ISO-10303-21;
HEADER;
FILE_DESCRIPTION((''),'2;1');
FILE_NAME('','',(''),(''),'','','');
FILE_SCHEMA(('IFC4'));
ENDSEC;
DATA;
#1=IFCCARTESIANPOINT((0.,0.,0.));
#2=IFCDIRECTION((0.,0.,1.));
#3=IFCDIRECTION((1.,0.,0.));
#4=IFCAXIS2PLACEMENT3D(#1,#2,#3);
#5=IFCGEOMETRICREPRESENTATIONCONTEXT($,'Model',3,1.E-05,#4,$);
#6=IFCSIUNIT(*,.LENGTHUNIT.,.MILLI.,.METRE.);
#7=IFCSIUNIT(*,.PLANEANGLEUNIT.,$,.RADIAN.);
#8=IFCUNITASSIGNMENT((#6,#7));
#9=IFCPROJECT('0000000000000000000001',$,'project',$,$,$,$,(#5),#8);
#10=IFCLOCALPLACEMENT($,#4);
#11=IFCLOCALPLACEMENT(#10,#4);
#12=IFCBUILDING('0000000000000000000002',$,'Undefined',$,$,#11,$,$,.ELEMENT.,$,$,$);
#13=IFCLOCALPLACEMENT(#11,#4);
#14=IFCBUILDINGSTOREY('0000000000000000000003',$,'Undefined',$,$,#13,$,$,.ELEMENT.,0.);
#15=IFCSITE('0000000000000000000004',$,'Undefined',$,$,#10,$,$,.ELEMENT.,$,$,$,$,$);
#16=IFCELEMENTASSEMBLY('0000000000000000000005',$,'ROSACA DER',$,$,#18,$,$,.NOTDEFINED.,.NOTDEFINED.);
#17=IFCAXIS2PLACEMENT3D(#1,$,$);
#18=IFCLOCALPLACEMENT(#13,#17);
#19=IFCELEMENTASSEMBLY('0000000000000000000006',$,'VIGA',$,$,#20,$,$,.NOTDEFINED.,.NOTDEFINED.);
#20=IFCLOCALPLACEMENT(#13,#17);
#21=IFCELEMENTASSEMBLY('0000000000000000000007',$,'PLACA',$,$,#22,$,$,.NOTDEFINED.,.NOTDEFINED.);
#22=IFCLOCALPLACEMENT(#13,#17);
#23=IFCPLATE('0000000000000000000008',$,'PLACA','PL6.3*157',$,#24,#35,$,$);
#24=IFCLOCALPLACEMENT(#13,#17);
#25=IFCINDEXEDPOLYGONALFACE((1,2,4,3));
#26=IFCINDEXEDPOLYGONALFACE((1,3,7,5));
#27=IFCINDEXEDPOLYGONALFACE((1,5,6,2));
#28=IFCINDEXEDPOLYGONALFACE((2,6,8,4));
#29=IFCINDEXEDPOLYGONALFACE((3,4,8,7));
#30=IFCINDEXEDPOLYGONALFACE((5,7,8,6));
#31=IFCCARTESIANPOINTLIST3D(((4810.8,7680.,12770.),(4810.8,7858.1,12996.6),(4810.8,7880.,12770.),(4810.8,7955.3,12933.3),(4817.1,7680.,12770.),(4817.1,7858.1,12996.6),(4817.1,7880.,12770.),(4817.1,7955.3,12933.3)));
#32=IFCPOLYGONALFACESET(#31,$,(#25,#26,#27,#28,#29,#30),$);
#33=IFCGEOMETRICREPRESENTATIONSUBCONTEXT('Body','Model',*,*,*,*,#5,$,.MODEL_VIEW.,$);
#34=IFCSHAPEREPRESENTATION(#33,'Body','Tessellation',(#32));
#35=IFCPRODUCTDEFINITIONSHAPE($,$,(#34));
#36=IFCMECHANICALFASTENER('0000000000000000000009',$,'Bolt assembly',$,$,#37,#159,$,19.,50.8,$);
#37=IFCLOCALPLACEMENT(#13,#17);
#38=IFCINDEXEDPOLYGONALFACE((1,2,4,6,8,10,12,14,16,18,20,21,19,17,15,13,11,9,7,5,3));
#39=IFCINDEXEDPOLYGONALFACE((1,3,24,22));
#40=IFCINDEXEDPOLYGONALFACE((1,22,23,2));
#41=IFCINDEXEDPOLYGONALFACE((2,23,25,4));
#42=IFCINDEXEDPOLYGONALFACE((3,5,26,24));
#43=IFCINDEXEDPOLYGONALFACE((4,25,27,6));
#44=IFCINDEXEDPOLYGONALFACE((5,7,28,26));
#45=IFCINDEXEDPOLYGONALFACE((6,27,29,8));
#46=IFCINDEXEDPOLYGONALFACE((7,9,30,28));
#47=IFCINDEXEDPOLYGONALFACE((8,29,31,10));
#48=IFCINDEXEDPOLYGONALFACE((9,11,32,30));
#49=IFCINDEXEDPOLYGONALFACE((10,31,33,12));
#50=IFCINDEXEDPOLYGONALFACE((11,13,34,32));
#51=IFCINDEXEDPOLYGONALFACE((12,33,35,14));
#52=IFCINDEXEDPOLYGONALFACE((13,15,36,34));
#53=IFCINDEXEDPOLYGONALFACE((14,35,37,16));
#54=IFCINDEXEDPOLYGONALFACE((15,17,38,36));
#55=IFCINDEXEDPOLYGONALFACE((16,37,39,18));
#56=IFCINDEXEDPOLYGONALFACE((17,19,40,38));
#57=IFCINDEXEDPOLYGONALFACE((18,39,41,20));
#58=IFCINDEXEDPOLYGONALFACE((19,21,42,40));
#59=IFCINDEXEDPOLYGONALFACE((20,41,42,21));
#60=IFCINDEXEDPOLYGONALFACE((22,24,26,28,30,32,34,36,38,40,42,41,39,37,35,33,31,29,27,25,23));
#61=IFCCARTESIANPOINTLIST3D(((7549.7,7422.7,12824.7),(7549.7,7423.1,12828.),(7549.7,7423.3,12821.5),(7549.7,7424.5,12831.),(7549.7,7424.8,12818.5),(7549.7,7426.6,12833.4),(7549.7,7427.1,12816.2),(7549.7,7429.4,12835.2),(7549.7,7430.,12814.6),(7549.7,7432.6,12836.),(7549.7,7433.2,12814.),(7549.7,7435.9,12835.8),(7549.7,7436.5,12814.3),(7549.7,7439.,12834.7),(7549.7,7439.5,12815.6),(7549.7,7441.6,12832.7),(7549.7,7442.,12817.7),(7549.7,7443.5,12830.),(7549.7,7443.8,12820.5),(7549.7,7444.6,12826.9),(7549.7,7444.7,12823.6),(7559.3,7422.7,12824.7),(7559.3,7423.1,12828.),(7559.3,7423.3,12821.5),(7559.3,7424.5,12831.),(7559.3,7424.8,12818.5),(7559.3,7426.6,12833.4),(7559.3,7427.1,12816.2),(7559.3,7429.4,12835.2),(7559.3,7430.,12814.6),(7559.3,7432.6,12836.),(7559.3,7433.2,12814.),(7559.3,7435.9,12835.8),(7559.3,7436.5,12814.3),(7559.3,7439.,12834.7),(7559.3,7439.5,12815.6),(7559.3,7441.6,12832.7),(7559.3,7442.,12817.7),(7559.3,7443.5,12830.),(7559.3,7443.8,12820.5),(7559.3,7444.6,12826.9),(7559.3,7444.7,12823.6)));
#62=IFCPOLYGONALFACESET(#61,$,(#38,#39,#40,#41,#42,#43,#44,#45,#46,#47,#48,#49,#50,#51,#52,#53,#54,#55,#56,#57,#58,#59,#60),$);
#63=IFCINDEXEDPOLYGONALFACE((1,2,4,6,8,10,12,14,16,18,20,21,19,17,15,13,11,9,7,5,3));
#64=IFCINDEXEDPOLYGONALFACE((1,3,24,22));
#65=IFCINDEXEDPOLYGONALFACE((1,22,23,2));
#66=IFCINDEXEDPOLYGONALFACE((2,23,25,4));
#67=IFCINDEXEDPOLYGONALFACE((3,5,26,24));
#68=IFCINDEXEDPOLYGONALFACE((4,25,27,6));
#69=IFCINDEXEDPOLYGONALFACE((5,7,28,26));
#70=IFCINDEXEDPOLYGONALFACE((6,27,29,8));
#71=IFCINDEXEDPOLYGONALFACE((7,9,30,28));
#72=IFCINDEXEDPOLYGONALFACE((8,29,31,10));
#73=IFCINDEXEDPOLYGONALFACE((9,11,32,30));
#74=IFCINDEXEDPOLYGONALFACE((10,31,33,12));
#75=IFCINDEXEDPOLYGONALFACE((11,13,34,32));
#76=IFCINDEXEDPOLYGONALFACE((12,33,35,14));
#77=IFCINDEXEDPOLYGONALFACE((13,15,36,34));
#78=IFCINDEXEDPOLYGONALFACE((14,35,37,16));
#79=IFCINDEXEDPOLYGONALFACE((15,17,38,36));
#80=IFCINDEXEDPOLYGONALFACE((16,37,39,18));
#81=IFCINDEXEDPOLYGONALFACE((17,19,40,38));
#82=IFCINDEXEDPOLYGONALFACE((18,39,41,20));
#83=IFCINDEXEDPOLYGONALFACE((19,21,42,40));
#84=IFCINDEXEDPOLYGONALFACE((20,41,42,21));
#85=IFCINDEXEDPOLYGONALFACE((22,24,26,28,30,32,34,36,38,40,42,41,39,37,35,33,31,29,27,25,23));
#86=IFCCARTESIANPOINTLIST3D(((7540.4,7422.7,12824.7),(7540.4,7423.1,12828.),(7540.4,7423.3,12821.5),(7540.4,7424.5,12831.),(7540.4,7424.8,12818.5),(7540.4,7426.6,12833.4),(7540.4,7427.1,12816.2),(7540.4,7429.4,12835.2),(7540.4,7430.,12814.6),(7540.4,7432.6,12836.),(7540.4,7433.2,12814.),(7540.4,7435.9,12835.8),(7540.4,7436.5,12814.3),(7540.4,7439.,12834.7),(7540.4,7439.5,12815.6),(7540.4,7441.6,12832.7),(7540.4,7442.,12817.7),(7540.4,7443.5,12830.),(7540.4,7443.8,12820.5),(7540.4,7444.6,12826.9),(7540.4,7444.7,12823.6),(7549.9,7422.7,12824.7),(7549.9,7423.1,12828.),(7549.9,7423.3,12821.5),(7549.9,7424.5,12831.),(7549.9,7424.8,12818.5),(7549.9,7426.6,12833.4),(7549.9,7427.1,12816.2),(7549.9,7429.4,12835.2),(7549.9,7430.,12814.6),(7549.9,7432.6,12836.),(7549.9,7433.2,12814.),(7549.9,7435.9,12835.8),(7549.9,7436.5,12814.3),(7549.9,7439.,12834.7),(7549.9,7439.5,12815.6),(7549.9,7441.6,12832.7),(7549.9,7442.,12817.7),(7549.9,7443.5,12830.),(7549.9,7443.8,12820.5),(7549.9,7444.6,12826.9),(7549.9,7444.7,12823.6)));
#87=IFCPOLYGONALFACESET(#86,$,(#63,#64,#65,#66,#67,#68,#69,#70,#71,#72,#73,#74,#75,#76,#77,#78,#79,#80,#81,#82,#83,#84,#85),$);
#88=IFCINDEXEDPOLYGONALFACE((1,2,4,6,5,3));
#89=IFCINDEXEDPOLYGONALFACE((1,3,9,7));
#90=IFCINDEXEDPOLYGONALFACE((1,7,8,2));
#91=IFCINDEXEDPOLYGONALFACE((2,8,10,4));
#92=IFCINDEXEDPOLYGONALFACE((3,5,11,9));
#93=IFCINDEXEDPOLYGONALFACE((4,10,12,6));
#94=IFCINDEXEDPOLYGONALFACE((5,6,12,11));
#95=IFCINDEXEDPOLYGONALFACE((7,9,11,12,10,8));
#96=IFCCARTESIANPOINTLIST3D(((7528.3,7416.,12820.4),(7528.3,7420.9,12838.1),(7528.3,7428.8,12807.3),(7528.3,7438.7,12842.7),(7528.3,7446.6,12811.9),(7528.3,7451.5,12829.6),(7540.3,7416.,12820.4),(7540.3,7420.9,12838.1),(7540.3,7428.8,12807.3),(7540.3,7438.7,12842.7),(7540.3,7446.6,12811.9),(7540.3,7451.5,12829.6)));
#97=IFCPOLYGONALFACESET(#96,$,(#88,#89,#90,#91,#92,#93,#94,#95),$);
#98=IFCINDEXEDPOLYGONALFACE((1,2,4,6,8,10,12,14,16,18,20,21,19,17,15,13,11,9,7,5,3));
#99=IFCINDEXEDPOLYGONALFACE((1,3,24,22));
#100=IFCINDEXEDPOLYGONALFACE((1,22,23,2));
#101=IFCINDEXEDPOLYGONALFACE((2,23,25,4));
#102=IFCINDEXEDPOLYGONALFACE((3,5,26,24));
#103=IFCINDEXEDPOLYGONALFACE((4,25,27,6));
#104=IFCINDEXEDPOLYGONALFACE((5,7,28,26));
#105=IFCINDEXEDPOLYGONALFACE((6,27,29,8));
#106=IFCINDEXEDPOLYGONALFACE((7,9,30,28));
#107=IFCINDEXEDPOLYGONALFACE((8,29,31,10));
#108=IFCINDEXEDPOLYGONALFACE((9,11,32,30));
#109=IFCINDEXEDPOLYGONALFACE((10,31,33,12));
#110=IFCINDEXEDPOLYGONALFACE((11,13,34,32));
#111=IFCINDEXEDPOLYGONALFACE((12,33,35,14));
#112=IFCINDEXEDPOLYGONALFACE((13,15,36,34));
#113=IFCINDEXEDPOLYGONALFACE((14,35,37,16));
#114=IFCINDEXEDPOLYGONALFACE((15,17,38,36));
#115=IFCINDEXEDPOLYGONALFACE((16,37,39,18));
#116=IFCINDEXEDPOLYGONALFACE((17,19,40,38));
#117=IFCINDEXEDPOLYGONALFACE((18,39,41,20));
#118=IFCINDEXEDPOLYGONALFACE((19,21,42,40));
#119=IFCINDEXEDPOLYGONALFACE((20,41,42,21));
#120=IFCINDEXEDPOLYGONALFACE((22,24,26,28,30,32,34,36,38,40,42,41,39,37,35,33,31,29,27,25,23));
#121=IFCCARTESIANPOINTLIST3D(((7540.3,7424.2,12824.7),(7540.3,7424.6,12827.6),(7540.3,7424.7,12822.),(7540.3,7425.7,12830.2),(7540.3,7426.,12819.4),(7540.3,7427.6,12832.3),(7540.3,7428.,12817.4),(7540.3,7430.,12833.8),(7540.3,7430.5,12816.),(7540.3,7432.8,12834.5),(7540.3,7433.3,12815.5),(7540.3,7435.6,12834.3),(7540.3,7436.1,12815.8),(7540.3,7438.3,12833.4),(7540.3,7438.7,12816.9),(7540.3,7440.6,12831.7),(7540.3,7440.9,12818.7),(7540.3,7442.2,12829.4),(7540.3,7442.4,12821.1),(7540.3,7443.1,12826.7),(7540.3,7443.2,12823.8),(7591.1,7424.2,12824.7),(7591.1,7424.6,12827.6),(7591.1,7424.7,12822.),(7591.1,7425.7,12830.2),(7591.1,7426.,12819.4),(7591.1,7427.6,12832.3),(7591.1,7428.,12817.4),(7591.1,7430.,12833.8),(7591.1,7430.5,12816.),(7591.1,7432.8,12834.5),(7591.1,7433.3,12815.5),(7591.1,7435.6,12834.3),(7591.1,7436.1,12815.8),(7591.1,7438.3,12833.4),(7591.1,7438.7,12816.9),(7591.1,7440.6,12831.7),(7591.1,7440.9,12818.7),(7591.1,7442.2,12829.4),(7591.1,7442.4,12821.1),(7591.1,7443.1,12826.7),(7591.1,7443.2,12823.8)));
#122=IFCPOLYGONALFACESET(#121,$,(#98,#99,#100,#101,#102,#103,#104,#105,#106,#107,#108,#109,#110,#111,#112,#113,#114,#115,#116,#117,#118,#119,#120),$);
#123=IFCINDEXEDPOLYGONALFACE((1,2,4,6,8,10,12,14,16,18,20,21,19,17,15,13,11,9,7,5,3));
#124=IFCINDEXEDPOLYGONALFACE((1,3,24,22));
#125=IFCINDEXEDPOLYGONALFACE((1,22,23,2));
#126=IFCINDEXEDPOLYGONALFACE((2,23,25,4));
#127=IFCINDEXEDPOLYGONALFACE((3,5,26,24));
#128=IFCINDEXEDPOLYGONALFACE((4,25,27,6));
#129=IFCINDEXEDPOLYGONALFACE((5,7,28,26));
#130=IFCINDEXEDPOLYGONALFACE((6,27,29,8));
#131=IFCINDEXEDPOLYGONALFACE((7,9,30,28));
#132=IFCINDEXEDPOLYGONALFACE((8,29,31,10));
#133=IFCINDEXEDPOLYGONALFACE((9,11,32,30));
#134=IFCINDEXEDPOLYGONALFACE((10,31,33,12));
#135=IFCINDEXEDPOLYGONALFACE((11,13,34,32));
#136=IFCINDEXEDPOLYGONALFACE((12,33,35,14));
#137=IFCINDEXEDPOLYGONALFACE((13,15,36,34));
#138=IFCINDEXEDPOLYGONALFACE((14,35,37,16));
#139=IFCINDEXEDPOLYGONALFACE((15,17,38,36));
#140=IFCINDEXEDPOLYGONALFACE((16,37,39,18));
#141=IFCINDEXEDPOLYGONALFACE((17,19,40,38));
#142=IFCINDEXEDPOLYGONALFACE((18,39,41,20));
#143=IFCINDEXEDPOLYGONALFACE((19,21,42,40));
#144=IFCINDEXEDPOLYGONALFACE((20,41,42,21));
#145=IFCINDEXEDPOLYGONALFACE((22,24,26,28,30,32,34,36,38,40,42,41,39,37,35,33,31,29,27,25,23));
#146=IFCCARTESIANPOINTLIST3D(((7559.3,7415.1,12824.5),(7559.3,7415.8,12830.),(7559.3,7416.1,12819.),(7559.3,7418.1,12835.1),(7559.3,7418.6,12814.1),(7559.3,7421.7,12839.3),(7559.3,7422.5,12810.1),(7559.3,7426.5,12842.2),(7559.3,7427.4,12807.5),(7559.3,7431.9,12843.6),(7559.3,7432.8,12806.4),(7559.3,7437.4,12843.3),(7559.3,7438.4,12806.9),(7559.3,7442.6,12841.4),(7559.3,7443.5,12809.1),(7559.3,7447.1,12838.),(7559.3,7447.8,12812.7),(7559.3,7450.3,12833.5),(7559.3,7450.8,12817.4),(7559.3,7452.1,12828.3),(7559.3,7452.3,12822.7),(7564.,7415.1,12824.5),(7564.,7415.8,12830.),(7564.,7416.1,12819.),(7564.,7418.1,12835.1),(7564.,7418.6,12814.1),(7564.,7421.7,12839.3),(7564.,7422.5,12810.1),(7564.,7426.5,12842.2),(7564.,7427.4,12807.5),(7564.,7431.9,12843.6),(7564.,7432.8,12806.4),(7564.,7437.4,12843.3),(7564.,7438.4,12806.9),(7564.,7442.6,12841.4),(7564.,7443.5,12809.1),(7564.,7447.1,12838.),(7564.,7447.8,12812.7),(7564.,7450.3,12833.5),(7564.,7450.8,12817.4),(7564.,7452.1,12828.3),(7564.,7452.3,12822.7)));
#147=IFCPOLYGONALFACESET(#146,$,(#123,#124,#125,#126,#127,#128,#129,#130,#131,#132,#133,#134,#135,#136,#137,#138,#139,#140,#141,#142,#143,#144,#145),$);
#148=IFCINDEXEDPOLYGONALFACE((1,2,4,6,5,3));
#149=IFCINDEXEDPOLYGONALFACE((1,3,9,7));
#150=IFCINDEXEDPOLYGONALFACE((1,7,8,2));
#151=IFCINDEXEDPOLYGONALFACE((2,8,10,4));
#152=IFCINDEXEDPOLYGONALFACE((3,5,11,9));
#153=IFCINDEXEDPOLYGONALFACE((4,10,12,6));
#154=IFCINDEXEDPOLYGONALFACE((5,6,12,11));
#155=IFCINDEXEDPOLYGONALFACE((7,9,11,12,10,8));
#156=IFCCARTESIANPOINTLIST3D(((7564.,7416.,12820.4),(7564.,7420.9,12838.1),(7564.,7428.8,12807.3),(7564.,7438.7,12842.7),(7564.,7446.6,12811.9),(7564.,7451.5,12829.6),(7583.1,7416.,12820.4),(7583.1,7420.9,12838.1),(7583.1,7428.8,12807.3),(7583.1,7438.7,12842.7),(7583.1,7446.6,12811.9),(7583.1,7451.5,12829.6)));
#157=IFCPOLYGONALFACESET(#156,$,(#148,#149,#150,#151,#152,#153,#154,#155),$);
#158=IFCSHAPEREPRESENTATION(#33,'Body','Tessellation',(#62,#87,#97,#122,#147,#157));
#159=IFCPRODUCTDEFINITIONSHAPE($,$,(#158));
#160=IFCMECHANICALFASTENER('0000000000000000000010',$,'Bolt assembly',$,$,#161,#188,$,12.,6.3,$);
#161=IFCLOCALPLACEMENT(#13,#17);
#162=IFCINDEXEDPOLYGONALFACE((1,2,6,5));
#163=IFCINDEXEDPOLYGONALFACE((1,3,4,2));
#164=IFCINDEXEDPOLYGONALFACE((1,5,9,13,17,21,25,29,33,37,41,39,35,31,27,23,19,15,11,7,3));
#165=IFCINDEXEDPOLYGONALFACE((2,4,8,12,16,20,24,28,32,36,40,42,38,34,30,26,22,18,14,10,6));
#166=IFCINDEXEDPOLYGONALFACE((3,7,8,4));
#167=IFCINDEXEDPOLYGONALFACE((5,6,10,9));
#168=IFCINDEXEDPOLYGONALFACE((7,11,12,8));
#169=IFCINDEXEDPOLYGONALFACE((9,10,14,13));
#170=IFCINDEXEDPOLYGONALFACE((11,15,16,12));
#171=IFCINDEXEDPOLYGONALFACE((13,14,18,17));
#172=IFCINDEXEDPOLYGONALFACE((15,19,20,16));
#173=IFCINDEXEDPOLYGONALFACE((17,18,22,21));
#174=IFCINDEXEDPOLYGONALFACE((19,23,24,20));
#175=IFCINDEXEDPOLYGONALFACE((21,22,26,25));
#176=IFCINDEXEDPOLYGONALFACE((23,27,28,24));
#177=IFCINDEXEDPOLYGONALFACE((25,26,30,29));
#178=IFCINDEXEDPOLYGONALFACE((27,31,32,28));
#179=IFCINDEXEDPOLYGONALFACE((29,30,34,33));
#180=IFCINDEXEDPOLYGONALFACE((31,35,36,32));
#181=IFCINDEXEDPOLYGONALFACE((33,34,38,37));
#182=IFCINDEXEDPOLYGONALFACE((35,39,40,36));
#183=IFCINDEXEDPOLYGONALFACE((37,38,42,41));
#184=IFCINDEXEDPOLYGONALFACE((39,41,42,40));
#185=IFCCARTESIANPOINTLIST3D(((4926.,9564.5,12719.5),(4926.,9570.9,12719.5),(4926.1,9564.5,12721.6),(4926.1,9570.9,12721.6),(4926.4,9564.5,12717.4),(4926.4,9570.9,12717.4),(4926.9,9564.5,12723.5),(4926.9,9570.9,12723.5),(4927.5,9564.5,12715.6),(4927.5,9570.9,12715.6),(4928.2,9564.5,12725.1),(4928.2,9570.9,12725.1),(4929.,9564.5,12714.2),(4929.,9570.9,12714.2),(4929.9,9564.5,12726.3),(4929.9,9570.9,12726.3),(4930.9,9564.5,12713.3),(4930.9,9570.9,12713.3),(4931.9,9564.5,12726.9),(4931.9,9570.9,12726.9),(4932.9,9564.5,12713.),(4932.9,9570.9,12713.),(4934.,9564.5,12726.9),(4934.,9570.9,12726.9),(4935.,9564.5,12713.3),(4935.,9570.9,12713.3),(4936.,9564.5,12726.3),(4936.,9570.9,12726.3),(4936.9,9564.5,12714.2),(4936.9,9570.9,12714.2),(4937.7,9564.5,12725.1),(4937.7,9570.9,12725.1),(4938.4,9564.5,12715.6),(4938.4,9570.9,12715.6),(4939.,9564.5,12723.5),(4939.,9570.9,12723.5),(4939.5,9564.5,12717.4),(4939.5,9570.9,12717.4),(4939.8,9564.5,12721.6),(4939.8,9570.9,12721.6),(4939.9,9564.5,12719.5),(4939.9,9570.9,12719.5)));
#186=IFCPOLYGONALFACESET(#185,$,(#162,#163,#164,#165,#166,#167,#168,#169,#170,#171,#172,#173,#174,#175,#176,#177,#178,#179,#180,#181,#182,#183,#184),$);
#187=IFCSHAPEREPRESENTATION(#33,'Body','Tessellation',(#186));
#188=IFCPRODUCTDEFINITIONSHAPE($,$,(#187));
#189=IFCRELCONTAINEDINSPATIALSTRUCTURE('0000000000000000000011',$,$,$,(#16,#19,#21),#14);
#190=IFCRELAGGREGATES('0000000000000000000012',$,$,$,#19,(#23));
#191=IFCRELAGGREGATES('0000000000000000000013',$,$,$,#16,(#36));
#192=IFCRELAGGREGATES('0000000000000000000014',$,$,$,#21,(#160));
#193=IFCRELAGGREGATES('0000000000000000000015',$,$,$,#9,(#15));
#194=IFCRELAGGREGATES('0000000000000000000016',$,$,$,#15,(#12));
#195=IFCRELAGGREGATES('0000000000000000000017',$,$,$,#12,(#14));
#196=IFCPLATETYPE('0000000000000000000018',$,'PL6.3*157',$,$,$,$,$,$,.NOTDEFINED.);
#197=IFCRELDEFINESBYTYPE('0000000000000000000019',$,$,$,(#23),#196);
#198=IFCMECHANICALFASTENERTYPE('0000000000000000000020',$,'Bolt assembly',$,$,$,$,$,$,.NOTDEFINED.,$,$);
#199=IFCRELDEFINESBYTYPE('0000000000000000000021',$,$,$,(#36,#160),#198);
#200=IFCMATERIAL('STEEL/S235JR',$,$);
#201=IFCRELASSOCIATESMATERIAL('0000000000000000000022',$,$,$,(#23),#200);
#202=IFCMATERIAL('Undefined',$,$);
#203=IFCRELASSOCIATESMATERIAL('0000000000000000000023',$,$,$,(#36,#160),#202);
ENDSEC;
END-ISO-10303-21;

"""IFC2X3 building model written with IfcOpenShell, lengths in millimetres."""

from ifc_helpers import new_model, si_unit, frame, origin_with_axes, origin_2d_with_axis, place, context, subcontext, project, spatial, polyline, circle, outline, extrude, source, transform, mapped, material, type_object, element, aggregate, save


model = new_model("IFC2X3")

# Units and contexts
model_context = context("Model", 3, precision=1e-05, world=origin_with_axes())
body_context = subcontext(model_context, "Body", "Model", "MODEL_VIEW")
ifc_project = project(units=[si_unit("LENGTHUNIT", "METRE", prefix="MILLI"), si_unit("PLANEANGLEUNIT", "RADIAN")], contexts=[model_context])

# Site, building, storey
site_placement = place(None, origin_with_axes())
site = spatial("IfcSite", under=ifc_project, at=site_placement, Name="Undefined", CompositionType="ELEMENT")
building_placement = place(site_placement, origin_with_axes())
building = spatial("IfcBuilding", under=site, at=building_placement, Name="Undefined", CompositionType="ELEMENT")
storey_placement = place(building_placement, origin_with_axes())
storey = spatial("IfcBuildingStorey", under=building, at=storey_placement, Name="Undefined", CompositionType="ELEMENT", Elevation=0.0)

# Shared definitions
ifc_material_1 = material(Name="STEEL/S235JR")

# Element assembly
assembly_1_placement = place(storey_placement, origin_with_axes())
assembly_1 = element("IfcElementAssembly", 1, at=assembly_1_placement, inside=storey, Name="ROSACA DER", AssemblyPlace="NOTDEFINED", PredefinedType="NOTDEFINED")

# Element assembly
assembly_2_placement = place(storey_placement, origin_with_axes())
assembly_2 = element("IfcElementAssembly", 2, at=assembly_2_placement, inside=storey, Name="VIGA", AssemblyPlace="NOTDEFINED", PredefinedType="NOTDEFINED")

# Element assembly
assembly_3_placement = place(storey_placement, origin_with_axes())
assembly_3 = element("IfcElementAssembly", 3, at=assembly_3_placement, inside=storey, Name="PLACA", AssemblyPlace="NOTDEFINED", PredefinedType="NOTDEFINED")

# Plate
plate_type_1 = type_object("IfcPlateType", Name="PL6.3*157", PredefinedType="NOTDEFINED")
plate_1_placement = place(assembly_2_placement, frame((4813.9, 7680.0, 12770.0), z_axis=(1.0, 0.0, 0.0), x_axis=(0.0, 1.0, 0.0)))
plate_1 = element("IfcPlate", 4, at=plate_1_placement, type_object=plate_type_1, material=ifc_material_1, Name="PLACA", Description="PL6.3*157", context=body_context, shape_type="SweptSolid", body=[
    extrude(outline(polyline([(0.0, 0.0), (200.0, 0.0), (275.3, 163.3), (178.1, 226.6), (0.0, 0.0)])), frame((0.0, 0.0, -3.1), z_axis=(0.0, 0.0, 1.0), x_axis=(1.0, 0.0, 0.0)), (0.0, 0.0, 1.0), 6.3),
])
aggregate(assembly_2, [plate_1])

# Shared definitions
ifc_material_2 = material(Name="Undefined")
mechanical_fastener_type = type_object("IfcMechanicalFastenerType", Name="Bolt assembly")

# Mechanical fasteners
shared_shape_1 = source(origin_with_axes(), body_context, "Body", "SweptSolid", [
    extrude(circle(Radius=11.0, at=origin_2d_with_axis()), frame((0.0, 4.6, 0.0), z_axis=(0.0, 1.0, 0.0), x_axis=(1.0, 0.0, 0.0)), (0.0, 0.0, 1.0), 9.6),
    extrude(circle(Radius=11.0, at=origin_2d_with_axis()), frame((0.0, -4.6, 0.0), z_axis=(0.0, 1.0, 0.0), x_axis=(1.0, 0.0, 0.0)), (0.0, 0.0, 1.0), 9.5),
    extrude(outline(polyline([(15.9, -9.2), (15.9, 9.2), (0.0, 18.3), (-15.9, 9.2), (-15.9, -9.2), (0.0, -18.3), (15.9, -9.2)])), frame((0.0, -16.7, 0.0), z_axis=(0.0, 1.0, 0.0), x_axis=(1.0, 0.0, 0.0)), (0.0, 0.0, 1.0), 11.9),
    extrude(circle(Radius=9.5, at=origin_2d_with_axis()), frame((0.0, -4.7, 0.0), z_axis=(0.0, 1.0, 0.0), x_axis=(1.0, 0.0, 0.0)), (0.0, 0.0, 1.0), 50.8),
    extrude(circle(Radius=18.7, at=origin_2d_with_axis()), frame((0.0, 14.2, 0.0), z_axis=(0.0, 1.0, 0.0), x_axis=(1.0, 0.0, 0.0)), (0.0, 0.0, 1.0), 4.8),
    extrude(outline(polyline([(15.9, -9.2), (15.9, 9.2), (0.0, 18.3), (-15.9, 9.2), (-15.9, -9.2), (0.0, -18.3), (15.9, -9.2)])), frame((0.0, 19.0, 0.0), z_axis=(0.0, 1.0, 0.0), x_axis=(1.0, 0.0, 0.0)), (0.0, 0.0, 1.0), 19.1),
])
mechanical_fastener_1_placement = place(assembly_1_placement, frame((7545.0, 7433.7, 12825.0), z_axis=(0.0, 0.269162, 0.963095), x_axis=(0.0, -0.963095, 0.269162)))
mechanical_fastener_1 = element("IfcMechanicalFastener", 5, at=mechanical_fastener_1_placement, type_object=mechanical_fastener_type, material=ifc_material_2, Name="Bolt assembly", NominalDiameter=19.0, NominalLength=50.8, context=body_context, shape_type="MappedRepresentation", body=[
    mapped(shared_shape_1, transform((0.0, 0.0, 0.0))),
])
aggregate(assembly_1, [mechanical_fastener_1])
shared_shape_2 = source(origin_with_axes(), body_context, "Body", "SweptSolid", [
    extrude(circle(Radius=7.0, at=origin_2d_with_axis()), frame((0.0, -16.4, 0.0), z_axis=(0.0, 1.0, 0.0), x_axis=(1.0, 0.0, 0.0)), (0.0, 0.0, 1.0), 6.5),
])
mechanical_fastener_2_placement = place(assembly_3_placement, frame((4932.9, 9580.9, 12720.0), z_axis=(1.0, 0.0, 0.0), x_axis=(0.0, 0.0, -1.0)))
mechanical_fastener_2 = element("IfcMechanicalFastener", 6, at=mechanical_fastener_2_placement, type_object=mechanical_fastener_type, material=ifc_material_2, Name="Bolt assembly", NominalDiameter=12.0, NominalLength=6.3, context=body_context, shape_type="MappedRepresentation", body=[
    mapped(shared_shape_2, transform((0.0, 0.0, 0.0))),
])
aggregate(assembly_3, [mechanical_fastener_2])

save(model, "model.ifc")
